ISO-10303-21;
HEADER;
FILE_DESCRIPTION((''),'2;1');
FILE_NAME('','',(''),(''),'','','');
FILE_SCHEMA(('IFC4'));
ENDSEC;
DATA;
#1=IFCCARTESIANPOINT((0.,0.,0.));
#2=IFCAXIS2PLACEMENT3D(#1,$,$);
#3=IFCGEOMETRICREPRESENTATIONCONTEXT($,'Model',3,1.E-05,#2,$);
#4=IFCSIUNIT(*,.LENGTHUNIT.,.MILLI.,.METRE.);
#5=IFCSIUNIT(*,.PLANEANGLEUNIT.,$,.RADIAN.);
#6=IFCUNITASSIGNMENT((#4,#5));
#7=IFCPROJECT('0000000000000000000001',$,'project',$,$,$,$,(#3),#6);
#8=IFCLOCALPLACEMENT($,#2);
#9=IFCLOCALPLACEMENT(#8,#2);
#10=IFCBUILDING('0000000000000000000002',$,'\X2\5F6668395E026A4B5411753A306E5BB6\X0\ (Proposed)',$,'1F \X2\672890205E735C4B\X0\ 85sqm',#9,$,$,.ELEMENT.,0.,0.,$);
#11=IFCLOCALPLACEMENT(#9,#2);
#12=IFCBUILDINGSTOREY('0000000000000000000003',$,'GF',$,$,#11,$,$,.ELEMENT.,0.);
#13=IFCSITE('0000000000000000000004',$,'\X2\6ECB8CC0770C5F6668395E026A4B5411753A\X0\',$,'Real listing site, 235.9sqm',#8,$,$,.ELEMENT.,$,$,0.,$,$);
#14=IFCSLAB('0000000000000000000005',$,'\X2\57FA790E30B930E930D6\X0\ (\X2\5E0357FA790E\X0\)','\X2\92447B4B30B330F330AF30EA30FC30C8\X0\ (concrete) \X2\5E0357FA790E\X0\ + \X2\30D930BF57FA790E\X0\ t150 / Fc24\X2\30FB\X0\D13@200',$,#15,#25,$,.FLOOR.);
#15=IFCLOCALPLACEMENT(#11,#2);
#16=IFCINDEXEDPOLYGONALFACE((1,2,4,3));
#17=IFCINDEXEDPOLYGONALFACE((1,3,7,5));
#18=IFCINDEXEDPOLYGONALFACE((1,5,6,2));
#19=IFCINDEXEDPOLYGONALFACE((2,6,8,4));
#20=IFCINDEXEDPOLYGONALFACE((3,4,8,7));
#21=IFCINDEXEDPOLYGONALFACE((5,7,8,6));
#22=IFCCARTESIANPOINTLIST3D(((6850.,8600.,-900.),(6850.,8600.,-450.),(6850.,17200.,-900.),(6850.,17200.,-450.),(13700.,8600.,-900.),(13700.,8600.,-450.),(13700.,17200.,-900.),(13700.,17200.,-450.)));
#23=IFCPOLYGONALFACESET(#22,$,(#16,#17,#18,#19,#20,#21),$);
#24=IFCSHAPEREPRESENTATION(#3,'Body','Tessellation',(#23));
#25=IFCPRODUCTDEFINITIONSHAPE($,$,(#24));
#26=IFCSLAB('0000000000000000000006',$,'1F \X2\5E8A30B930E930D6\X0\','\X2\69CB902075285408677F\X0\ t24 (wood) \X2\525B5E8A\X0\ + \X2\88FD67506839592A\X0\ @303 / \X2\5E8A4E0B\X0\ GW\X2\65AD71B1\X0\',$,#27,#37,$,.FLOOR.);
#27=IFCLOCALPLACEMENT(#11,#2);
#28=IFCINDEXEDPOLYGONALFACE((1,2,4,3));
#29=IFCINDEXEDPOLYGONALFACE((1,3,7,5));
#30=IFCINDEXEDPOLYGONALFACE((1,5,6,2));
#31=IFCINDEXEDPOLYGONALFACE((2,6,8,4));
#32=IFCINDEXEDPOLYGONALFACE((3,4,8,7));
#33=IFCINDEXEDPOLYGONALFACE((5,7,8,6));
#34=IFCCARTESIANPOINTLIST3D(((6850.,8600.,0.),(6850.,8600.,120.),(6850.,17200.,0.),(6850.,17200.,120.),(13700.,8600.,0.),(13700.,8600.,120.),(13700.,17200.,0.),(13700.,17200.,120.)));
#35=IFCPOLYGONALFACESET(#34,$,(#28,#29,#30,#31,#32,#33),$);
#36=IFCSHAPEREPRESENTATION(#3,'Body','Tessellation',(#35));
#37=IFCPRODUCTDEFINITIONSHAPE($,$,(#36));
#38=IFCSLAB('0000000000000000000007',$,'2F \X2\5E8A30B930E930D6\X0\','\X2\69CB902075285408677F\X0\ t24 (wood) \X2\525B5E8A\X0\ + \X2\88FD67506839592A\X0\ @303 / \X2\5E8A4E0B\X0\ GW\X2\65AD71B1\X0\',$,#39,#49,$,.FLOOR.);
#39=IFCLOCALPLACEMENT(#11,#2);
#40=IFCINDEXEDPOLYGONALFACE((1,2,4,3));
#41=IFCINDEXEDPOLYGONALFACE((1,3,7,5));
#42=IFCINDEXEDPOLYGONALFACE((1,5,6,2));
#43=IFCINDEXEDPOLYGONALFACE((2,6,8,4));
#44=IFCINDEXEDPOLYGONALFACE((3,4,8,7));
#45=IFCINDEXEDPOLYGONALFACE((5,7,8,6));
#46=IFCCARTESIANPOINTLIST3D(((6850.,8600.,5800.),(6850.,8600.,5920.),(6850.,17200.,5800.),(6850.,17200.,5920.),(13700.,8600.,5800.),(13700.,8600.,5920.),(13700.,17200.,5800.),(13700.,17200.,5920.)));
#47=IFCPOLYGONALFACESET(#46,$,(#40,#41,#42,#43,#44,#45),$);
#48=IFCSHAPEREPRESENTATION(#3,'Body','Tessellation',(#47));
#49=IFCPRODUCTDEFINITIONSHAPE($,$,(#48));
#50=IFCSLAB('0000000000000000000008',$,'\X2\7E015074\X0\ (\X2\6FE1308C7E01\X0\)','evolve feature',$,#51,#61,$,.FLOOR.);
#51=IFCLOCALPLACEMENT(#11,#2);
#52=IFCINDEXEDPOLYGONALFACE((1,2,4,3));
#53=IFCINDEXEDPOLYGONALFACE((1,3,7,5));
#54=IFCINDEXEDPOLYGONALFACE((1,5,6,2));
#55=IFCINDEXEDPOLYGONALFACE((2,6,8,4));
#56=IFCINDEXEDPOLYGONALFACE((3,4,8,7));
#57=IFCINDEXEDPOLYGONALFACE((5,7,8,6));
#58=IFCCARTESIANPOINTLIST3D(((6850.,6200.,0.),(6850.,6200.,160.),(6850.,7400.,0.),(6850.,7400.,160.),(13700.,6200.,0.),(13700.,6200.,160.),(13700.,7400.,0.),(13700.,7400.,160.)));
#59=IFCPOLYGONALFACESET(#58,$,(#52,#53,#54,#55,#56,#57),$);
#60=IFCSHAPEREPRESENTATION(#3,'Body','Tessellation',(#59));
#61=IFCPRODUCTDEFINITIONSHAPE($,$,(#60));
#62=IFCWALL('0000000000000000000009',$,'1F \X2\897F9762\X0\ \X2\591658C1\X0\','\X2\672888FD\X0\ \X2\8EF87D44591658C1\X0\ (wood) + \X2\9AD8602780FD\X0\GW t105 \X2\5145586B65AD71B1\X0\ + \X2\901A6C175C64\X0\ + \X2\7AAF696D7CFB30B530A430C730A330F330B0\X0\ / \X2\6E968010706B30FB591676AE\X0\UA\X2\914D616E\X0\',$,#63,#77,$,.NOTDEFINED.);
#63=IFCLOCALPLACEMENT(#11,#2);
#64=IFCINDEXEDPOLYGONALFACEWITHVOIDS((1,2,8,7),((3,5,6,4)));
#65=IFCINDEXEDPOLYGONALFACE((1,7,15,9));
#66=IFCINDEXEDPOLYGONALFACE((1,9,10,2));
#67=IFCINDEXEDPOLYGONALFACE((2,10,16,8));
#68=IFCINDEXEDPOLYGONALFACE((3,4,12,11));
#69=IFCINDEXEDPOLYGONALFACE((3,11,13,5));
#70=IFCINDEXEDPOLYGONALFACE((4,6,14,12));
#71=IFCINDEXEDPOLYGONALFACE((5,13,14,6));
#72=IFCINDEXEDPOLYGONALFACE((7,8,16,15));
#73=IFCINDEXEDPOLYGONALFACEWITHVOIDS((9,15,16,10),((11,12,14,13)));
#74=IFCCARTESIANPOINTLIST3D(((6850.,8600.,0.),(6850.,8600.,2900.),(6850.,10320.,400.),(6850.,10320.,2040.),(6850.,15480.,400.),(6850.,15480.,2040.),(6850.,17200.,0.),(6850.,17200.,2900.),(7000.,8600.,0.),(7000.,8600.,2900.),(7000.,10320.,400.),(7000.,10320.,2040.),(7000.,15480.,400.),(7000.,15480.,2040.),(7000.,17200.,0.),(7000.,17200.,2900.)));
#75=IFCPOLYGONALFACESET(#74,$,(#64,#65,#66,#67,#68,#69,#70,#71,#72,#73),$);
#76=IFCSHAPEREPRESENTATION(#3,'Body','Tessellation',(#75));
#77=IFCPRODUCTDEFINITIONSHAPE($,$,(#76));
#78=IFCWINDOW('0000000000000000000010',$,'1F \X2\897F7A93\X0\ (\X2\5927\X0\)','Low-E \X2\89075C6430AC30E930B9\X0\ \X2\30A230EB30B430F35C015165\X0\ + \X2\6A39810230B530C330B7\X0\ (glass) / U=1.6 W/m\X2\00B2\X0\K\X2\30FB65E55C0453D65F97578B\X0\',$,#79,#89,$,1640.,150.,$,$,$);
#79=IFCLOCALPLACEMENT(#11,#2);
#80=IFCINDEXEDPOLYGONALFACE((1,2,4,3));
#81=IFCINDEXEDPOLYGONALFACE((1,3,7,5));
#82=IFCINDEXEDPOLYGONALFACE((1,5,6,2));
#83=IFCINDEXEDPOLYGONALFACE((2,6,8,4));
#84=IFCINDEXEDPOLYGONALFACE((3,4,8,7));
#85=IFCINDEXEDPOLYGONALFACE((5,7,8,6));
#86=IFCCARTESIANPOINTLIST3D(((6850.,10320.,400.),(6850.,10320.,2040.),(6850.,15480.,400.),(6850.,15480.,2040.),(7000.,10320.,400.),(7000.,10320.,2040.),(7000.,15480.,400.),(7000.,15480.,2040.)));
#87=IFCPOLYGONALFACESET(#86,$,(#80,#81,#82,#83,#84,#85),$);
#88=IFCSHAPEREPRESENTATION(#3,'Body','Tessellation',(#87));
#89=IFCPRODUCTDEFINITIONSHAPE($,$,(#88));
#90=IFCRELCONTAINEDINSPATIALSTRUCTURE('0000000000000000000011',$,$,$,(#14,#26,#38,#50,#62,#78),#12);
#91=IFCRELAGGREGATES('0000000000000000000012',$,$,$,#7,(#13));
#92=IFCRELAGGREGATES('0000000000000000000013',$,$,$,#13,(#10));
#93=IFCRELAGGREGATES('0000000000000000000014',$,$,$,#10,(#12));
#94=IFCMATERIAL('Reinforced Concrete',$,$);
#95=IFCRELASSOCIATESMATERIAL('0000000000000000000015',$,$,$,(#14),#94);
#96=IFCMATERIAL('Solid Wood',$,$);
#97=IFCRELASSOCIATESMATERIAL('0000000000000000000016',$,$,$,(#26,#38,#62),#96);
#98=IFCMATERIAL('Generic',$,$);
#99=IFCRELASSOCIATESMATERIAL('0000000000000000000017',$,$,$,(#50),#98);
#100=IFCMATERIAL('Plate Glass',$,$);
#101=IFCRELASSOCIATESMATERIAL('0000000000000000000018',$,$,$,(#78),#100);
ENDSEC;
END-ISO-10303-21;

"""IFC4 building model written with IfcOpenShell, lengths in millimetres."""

from ifc_helpers import new_model, si_unit, frame, frame_2d, origin, place, context, project, spatial, rectangle, extrude, material, element, fill, save


model = new_model("IFC4")

# Units and contexts
model_context = context("Model", 3, precision=1e-05, world=origin())
ifc_project = project(units=[si_unit("LENGTHUNIT", "METRE", prefix="MILLI"), si_unit("PLANEANGLEUNIT", "RADIAN")], contexts=[model_context])

# Site, building, storey
site_placement = place(None, origin())
site = spatial("IfcSite", under=ifc_project, at=site_placement, Name="滋賀県彦根市橋向町", ObjectType="Real listing site, 235.9sqm", CompositionType="ELEMENT", RefElevation=0.0)
building_placement = place(site_placement, origin())
building = spatial("IfcBuilding", under=site, at=building_placement, Name="彦根市橋向町の家 (Proposed)", ObjectType="1F 木造平屋 85sqm", CompositionType="ELEMENT", ElevationOfRefHeight=0.0, ElevationOfTerrain=0.0)
storey_placement = place(building_placement, origin())
storey = spatial("IfcBuildingStorey", under=building, at=storey_placement, Name="GF", CompositionType="ELEMENT", Elevation=0.0)

# Slabs
ifc_material_1 = material(Name="Reinforced Concrete")
slab_1_placement = place(storey_placement, frame((3425.0, 4300.0, -450.0)))
element("IfcSlab", 1, at=slab_1_placement, inside=storey, material=ifc_material_1, Name="基礎スラブ (布基礎)", Description="鉄筋コンクリート (concrete) 布基礎 + ベタ基礎 t150 / Fc24・D13@200", PredefinedType="FLOOR", context=model_context, shape_type="SweptSolid", body=[
    extrude(rectangle(XDim=6850.0, YDim=8600.0, at=frame_2d((3425.0, 4300.0))), frame((3425.0, 4300.0, -450.0)), (0.0, 0.0, 1.0), 450.0),
])
ifc_material_2 = material(Name="Solid Wood")
slab_2_placement = place(storey_placement, frame((3425.0, 4300.0, 0.0)))
element("IfcSlab", 2, at=slab_2_placement, inside=storey, material=ifc_material_2, Name="1F 床スラブ", Description="構造用合板 t24 (wood) 剛床 + 製材根太 @303 / 床下 GW断熱", PredefinedType="FLOOR", context=model_context, shape_type="SweptSolid", body=[
    extrude(rectangle(XDim=6850.0, YDim=8600.0, at=frame_2d((3425.0, 4300.0))), frame((3425.0, 4300.0, 0.0)), (0.0, 0.0, 1.0), 120.0),
])
slab_3_placement = place(storey_placement, frame((3425.0, 4300.0, 2900.0)))
element("IfcSlab", 3, at=slab_3_placement, inside=storey, material=ifc_material_2, Name="2F 床スラブ", Description="構造用合板 t24 (wood) 剛床 + 製材根太 @303 / 床下 GW断熱", PredefinedType="FLOOR", context=model_context, shape_type="SweptSolid", body=[
    extrude(rectangle(XDim=6850.0, YDim=8600.0, at=frame_2d((3425.0, 4300.0))), frame((3425.0, 4300.0, 2900.0)), (0.0, 0.0, 1.0), 120.0),
])
ifc_material_3 = material(Name="Generic")
slab_4_placement = place(storey_placement, frame((3425.0, 3100.0, 0.0)))
element("IfcSlab", 4, at=slab_4_placement, inside=storey, material=ifc_material_3, Name="縁側 (濡れ縁)", Description="evolve feature", PredefinedType="FLOOR", context=model_context, shape_type="SweptSolid", body=[
    extrude(rectangle(XDim=6850.0, YDim=1200.0, at=frame_2d((3425.0, 600.0))), frame((3425.0, 3100.0, 0.0)), (0.0, 0.0, 1.0), 160.0),
])

# Shared definitions
ifc_material_4 = material(Name="Plate Glass")

# Wall, opening, window
wall_1_placement = place(storey_placement, frame((3425.0, 4300.0, 0.0)))
wall_1 = element("IfcWall", 5, at=wall_1_placement, inside=storey, material=ifc_material_2, Name="1F 西面 外壁", Description="木製 軸組外壁 (wood) + 高性能GW t105 充填断熱 + 通気層 + 窯業系サイディング / 準耐火・外皮UA配慮", PredefinedType="NOTDEFINED", context=model_context, shape_type="SweptSolid", body=[
    extrude(rectangle(XDim=150.0, YDim=8600.0, at=frame_2d((75.0, 4300.0))), frame((3425.0, 4300.0, 0.0)), (0.0, 0.0, 1.0), 2900.0),
])
opening_1_placement = place(storey_placement, frame((3425.0, 5160.0, 200.0)))
opening_1 = element("IfcOpeningElement", 6, at=opening_1_placement, cuts=wall_1, PredefinedType="NOTDEFINED", context=model_context, shape_type="SweptSolid", body=[
    extrude(rectangle(XDim=150.0, YDim=5160.0, at=frame_2d((75.0, 2580.0))), frame((3425.0, 5160.0, 200.0)), (0.0, 0.0, 1.0), 1640.0),
])
window_1_placement = place(storey_placement, frame((3425.0, 5160.0, 200.0)))
window_1 = element("IfcWindow", 7, at=window_1_placement, inside=storey, material=ifc_material_4, Name="1F 西窓 (大)", Description="Low-E 複層ガラス アルゴン封入 + 樹脂サッシ (glass) / U=1.6 W/m²K・日射取得型", OverallHeight=1640.0, OverallWidth=150.0, context=model_context, shape_type="SweptSolid", body=[
    extrude(rectangle(XDim=150.0, YDim=5160.0, at=frame_2d((75.0, 2580.0))), frame((3425.0, 5160.0, 200.0)), (0.0, 0.0, 1.0), 1640.0),
])
fill(opening_1, window_1)

save(model, "model.ifc")
